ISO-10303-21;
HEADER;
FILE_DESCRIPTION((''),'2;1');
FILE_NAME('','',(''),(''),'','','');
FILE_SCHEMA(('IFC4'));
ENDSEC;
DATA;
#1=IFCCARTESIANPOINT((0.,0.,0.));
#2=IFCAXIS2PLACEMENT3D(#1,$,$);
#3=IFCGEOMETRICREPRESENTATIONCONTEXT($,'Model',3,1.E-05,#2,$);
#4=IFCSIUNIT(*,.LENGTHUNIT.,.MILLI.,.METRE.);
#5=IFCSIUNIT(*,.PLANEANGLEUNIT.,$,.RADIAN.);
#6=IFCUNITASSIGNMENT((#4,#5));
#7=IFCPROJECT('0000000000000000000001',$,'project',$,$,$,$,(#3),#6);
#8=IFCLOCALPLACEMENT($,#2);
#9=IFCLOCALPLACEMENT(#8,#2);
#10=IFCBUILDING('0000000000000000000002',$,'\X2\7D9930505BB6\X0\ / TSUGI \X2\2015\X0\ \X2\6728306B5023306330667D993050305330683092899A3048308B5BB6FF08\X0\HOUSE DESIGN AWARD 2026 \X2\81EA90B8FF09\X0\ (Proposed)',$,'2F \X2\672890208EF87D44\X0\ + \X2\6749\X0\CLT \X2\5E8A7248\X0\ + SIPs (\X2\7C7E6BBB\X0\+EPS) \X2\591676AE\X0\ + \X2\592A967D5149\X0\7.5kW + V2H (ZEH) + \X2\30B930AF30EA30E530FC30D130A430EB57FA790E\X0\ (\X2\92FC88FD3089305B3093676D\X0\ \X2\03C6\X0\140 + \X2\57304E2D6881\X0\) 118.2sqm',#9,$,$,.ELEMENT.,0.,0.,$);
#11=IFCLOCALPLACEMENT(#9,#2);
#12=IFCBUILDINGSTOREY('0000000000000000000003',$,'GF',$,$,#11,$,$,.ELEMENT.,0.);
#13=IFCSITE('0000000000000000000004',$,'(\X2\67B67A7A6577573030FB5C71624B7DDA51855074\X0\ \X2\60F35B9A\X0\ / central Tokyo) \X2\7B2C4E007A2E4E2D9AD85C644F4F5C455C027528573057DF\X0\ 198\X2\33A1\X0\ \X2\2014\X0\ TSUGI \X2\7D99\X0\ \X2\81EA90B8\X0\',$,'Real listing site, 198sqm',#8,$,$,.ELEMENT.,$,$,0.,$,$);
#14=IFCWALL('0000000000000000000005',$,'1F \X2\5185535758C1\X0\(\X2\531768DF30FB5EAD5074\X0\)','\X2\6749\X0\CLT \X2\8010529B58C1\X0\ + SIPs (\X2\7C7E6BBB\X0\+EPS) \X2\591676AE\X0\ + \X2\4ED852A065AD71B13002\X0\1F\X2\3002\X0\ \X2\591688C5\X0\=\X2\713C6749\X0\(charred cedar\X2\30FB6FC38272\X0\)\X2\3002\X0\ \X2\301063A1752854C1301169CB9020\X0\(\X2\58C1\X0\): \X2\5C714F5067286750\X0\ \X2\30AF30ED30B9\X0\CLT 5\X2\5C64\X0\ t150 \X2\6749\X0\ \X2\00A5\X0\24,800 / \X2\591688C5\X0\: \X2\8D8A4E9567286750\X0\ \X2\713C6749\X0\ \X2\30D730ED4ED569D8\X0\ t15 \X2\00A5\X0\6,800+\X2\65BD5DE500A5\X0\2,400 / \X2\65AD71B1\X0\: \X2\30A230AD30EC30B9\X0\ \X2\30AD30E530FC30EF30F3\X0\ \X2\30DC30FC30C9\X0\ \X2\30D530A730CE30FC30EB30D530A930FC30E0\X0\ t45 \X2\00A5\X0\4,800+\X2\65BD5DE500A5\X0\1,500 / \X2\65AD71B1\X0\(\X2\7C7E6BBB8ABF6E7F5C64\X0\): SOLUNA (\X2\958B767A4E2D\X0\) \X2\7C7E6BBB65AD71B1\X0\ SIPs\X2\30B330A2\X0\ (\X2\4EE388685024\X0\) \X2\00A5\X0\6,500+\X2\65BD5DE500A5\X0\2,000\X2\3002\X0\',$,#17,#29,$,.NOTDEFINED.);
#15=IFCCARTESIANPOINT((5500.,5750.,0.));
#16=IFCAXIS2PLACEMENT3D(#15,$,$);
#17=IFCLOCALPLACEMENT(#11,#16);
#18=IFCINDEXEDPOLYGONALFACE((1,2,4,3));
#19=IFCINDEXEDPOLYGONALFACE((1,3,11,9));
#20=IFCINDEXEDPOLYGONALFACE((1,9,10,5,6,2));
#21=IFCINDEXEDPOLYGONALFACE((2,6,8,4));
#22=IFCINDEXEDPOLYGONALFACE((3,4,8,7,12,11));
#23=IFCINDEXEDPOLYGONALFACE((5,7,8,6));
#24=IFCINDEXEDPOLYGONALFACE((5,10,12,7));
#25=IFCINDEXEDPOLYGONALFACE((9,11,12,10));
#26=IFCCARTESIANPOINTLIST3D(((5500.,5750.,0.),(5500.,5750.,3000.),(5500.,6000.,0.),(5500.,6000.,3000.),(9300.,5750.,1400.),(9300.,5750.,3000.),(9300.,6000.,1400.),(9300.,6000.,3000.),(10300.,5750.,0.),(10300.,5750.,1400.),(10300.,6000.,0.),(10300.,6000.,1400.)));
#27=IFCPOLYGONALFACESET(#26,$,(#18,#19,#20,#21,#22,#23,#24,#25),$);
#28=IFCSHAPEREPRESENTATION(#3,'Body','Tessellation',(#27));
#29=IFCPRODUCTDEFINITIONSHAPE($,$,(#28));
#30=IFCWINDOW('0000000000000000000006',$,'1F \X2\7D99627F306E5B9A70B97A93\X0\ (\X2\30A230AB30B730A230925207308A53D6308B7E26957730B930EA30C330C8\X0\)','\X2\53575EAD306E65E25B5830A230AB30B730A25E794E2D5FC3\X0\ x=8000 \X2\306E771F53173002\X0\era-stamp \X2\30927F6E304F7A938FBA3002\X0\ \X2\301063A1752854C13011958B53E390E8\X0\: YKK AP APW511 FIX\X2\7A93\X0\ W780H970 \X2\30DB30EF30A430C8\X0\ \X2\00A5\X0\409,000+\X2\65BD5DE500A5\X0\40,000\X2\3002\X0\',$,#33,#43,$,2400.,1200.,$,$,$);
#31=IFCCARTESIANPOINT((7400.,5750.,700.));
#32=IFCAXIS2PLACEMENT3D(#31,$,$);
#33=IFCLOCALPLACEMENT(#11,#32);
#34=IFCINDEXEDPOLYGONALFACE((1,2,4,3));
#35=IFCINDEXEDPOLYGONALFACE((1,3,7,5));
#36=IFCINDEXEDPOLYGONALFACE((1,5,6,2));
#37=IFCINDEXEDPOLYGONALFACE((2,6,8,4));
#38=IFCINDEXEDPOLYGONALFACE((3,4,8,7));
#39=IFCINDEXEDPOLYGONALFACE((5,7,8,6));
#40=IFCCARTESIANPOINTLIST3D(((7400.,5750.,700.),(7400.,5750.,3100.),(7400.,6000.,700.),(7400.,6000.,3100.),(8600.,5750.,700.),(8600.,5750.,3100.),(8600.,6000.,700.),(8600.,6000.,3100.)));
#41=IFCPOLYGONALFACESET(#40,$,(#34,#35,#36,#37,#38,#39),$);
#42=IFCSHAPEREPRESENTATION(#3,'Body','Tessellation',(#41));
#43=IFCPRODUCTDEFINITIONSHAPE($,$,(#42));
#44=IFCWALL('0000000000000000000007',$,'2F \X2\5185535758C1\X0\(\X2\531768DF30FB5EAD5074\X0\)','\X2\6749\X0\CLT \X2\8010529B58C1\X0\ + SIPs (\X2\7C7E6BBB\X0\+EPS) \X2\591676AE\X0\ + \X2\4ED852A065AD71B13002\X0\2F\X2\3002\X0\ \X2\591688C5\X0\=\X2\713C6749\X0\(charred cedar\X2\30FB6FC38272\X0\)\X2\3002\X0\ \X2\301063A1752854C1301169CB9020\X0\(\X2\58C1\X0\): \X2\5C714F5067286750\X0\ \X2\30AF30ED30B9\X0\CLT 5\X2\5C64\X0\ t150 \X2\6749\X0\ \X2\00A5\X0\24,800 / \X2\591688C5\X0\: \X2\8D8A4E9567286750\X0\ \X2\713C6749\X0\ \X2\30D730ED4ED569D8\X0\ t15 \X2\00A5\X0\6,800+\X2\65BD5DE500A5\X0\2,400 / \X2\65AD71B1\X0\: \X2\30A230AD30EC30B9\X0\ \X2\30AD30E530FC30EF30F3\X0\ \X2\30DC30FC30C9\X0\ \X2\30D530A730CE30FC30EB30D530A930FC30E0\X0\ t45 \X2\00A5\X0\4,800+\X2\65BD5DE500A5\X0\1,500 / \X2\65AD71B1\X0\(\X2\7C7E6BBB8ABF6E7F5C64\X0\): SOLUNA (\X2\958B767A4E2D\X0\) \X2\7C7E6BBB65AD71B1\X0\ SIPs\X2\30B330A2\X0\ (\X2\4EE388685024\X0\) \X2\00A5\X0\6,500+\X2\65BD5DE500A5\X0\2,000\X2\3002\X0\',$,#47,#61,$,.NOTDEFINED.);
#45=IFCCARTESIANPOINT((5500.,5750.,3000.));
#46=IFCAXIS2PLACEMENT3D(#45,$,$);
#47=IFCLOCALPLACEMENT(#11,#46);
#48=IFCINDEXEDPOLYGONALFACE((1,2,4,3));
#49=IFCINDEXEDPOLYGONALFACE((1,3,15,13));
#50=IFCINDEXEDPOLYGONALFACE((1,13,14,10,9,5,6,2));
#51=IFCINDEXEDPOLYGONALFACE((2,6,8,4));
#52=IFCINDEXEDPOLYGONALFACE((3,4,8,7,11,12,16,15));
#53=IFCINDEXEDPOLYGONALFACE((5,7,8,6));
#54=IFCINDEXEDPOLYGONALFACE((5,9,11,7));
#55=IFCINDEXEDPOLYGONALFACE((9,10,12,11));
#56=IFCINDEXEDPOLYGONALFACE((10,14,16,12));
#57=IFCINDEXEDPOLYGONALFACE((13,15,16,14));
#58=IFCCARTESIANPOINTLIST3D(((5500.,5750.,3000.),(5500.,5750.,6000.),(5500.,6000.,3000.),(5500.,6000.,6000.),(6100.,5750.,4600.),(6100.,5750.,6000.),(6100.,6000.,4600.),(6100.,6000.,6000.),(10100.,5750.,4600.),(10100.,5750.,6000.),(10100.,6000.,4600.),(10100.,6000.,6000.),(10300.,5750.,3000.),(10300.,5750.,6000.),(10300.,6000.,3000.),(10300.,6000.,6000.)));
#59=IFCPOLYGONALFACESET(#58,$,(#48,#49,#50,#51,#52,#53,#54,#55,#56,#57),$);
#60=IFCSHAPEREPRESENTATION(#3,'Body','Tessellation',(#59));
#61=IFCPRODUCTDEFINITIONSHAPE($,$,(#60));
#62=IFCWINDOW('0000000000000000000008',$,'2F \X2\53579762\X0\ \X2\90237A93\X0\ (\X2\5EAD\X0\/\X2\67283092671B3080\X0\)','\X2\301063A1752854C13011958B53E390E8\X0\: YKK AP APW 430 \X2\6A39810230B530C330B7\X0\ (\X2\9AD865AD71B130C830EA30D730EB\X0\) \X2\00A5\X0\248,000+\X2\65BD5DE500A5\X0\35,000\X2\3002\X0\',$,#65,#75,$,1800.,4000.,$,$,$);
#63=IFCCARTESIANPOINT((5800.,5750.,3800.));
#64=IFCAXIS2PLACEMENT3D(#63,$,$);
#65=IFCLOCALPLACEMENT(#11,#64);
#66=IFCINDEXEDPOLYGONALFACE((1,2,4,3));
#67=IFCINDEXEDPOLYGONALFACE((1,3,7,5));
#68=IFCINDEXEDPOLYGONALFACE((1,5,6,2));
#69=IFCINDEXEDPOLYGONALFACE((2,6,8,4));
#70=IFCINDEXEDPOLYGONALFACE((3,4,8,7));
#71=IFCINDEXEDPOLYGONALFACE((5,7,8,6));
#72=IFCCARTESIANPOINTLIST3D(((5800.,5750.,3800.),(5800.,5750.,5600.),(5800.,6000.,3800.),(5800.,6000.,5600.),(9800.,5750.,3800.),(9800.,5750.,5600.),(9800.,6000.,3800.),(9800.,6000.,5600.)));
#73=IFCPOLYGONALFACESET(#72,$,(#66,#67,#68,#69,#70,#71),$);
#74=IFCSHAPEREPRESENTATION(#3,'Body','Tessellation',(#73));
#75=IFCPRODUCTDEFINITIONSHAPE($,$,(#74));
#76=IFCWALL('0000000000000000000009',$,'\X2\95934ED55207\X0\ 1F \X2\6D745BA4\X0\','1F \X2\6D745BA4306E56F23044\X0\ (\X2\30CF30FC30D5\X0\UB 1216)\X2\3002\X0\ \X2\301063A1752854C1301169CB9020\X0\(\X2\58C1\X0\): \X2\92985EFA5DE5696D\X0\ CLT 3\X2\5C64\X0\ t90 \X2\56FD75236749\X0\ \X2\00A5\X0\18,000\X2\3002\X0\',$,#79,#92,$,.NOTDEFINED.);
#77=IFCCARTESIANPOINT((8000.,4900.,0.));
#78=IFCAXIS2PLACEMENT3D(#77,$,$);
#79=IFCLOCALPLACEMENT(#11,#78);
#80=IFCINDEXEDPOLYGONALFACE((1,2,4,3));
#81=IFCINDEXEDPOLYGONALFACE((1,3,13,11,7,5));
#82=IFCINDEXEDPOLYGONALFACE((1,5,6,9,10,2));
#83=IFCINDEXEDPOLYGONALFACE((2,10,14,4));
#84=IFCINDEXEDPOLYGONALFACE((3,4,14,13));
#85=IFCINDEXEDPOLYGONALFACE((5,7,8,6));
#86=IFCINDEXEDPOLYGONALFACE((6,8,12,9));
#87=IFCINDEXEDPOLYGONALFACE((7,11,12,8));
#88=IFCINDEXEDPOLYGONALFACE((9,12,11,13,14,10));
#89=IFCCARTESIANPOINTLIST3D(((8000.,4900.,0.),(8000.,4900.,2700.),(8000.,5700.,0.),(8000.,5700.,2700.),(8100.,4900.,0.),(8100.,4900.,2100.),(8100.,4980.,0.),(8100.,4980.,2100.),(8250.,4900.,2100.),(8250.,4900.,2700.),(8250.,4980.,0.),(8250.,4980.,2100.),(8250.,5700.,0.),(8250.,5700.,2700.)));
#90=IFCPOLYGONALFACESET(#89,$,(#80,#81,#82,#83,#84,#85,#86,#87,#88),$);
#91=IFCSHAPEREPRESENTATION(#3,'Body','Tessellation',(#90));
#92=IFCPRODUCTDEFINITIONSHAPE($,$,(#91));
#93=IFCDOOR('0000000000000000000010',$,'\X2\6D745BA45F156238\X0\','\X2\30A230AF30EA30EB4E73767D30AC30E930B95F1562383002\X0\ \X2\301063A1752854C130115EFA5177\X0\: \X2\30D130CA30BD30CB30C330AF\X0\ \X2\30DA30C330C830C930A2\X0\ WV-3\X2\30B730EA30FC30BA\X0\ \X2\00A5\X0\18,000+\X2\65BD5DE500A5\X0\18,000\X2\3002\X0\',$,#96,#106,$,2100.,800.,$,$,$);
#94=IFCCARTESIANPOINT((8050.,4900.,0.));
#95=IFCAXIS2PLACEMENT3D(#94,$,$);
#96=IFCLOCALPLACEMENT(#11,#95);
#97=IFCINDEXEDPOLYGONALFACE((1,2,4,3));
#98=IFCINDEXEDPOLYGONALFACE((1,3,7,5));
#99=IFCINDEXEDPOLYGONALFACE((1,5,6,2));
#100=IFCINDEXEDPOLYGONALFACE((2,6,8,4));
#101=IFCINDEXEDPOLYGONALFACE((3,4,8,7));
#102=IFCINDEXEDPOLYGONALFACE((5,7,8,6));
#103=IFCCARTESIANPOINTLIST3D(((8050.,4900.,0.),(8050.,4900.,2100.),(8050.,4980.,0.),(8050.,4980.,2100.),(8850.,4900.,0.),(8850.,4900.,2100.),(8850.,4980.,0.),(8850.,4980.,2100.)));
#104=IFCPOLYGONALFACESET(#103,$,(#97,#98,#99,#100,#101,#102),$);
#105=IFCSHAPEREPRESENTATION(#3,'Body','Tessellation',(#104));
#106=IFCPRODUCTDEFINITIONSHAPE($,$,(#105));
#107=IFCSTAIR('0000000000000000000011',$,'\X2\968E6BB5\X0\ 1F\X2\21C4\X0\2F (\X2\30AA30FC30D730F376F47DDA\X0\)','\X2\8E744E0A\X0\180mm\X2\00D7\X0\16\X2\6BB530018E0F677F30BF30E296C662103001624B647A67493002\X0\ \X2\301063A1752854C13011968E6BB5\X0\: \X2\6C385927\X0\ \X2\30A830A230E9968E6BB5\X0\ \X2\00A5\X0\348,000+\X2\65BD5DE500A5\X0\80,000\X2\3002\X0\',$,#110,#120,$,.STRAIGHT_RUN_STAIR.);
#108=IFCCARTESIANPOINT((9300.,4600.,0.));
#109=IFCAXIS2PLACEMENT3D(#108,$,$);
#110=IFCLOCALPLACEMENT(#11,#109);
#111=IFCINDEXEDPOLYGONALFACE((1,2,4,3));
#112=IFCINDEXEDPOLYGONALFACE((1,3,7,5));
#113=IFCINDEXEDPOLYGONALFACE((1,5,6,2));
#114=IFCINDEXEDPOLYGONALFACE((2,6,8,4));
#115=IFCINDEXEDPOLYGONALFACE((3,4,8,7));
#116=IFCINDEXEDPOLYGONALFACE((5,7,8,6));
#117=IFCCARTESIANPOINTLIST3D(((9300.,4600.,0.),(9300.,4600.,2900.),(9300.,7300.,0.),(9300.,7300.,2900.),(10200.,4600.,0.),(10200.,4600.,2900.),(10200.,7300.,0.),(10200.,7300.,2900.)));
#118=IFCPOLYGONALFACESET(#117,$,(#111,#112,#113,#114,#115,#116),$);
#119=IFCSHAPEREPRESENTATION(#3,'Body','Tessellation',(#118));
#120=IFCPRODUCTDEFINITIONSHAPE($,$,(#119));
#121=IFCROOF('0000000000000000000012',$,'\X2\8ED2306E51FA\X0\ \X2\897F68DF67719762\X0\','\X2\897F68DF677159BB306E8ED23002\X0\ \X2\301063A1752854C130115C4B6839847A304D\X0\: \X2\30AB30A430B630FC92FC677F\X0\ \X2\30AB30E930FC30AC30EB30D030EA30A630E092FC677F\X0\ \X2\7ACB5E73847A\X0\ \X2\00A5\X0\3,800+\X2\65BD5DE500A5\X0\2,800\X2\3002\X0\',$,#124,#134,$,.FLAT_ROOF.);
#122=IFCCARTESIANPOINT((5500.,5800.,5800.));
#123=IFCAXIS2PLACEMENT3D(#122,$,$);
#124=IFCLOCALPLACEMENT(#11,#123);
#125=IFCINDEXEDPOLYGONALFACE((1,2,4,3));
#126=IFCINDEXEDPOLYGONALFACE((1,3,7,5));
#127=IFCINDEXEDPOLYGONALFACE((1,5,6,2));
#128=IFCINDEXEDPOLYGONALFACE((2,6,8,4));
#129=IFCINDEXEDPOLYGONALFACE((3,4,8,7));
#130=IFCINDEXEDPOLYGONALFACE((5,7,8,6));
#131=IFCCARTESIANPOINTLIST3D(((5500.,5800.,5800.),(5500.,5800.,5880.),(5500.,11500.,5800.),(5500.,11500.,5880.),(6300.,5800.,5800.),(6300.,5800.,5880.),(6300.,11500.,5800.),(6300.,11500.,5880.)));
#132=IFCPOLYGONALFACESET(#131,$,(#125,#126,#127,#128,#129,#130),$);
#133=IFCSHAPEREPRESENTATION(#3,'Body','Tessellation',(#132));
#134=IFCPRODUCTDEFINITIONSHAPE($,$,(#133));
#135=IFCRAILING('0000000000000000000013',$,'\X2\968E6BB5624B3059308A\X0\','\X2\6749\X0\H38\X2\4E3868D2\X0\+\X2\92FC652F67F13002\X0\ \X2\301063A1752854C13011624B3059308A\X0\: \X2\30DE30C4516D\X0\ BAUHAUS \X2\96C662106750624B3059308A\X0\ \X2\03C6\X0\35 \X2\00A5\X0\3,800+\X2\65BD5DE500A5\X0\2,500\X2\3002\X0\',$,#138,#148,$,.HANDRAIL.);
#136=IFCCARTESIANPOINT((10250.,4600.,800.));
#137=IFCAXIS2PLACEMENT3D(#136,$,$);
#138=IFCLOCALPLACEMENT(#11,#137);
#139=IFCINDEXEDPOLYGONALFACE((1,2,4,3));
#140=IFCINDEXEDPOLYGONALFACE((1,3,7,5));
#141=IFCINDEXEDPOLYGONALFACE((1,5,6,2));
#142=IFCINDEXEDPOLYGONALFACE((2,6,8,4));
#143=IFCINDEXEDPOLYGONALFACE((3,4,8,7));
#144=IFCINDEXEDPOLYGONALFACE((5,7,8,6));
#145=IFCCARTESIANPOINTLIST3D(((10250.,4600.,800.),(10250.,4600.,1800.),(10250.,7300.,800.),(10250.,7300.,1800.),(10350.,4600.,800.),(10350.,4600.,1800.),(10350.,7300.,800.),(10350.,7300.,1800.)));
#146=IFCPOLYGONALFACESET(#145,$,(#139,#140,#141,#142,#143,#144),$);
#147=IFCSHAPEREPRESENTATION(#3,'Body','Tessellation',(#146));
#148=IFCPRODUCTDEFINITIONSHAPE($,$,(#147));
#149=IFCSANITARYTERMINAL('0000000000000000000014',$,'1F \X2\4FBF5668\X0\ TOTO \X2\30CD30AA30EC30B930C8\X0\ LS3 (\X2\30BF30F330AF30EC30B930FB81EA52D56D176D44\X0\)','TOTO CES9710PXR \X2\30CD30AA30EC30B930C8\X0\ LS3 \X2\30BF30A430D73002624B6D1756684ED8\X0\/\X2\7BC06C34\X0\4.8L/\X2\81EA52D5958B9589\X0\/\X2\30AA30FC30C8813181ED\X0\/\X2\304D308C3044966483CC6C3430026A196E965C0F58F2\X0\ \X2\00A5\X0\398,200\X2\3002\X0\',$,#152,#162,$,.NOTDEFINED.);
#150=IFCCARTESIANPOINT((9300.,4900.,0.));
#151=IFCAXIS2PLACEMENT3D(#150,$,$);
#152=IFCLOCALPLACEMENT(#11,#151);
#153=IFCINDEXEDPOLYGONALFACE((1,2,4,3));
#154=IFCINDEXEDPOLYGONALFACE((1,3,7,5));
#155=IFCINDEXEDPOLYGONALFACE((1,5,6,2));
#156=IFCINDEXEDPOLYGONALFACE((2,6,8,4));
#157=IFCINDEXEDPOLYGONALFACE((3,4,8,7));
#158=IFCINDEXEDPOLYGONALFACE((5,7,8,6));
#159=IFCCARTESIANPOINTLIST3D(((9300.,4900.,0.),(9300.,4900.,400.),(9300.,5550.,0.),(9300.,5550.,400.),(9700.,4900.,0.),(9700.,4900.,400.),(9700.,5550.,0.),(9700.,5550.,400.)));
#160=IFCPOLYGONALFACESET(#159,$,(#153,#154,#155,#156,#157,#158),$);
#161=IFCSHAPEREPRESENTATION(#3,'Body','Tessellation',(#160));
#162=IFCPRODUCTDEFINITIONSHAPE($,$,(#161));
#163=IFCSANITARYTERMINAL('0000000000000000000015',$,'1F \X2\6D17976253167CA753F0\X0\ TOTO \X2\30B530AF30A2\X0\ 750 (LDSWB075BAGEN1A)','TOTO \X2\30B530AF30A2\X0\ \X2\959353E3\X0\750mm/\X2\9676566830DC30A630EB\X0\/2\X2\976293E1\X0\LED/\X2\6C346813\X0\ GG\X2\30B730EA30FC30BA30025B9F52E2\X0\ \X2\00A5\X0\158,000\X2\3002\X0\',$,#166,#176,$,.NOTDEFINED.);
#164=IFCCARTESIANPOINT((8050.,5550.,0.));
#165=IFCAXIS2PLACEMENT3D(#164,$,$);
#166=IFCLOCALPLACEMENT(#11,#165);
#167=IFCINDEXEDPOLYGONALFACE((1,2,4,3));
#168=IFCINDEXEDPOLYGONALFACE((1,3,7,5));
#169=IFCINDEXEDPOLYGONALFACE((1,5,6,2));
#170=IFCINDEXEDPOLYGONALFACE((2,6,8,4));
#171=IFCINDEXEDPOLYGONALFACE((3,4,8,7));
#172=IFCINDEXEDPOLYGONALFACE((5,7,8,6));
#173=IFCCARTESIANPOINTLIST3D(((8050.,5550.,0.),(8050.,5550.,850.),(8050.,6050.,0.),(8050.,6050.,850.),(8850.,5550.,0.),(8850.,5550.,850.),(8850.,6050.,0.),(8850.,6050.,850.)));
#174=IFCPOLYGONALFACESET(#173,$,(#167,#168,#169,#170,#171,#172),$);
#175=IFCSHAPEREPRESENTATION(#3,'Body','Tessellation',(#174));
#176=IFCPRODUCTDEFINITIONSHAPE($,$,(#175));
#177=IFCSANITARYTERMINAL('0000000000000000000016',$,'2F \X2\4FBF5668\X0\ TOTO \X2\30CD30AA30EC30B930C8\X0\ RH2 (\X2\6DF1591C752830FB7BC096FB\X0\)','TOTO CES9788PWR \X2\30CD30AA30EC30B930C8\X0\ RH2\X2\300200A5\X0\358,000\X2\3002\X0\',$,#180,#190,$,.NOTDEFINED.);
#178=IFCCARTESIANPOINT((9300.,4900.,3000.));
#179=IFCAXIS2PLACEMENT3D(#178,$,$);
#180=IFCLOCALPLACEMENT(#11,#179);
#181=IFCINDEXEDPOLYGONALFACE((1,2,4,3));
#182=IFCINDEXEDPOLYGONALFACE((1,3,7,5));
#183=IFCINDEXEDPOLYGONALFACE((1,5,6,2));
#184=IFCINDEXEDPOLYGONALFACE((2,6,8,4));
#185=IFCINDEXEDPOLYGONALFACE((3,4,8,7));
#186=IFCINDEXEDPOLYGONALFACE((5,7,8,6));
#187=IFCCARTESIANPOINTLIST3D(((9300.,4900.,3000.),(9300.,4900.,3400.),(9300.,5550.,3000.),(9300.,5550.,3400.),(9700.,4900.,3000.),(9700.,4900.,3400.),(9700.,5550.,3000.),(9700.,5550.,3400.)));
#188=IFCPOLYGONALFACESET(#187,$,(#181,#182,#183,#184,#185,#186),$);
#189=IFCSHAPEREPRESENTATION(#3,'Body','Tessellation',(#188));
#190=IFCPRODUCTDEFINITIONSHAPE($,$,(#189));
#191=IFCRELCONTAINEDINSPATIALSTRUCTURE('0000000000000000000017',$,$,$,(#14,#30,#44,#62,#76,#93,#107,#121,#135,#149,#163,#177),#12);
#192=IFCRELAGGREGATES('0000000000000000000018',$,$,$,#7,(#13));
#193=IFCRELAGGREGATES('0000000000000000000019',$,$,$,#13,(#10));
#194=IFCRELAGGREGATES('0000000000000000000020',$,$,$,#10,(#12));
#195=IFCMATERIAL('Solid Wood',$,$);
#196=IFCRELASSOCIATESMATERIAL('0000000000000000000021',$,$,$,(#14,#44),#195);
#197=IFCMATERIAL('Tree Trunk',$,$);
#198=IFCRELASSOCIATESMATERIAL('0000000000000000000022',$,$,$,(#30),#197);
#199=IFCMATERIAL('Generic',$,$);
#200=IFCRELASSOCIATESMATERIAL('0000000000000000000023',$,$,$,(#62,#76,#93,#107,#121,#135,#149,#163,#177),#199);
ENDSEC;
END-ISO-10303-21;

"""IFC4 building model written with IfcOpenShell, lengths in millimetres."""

from ifc_helpers import new_model, si_unit, frame, frame_2d, origin, place, context, project, spatial, rectangle, extrude, material, element, fill, save


model = new_model("IFC4")

# Units and contexts
model_context = context("Model", 3, precision=1e-05, world=origin())
ifc_project = project(units=[si_unit("LENGTHUNIT", "METRE", prefix="MILLI"), si_unit("PLANEANGLEUNIT", "RADIAN")], contexts=[model_context])

# Site, building, storey
site_placement = place(None, origin())
site = spatial("IfcSite", under=ifc_project, at=site_placement, Name="(架空敷地・山手線内側 想定 / central Tokyo) 第一種中高層住居専用地域 198㎡ — TSUGI 継 自邸", ObjectType="Real listing site, 198sqm", CompositionType="ELEMENT", RefElevation=0.0)
building_placement = place(site_placement, origin())
building = spatial("IfcBuilding", under=site, at=building_placement, Name="継ぐ家 / TSUGI ― 木に倣って継ぐことを覚える家（HOUSE DESIGN AWARD 2026 自邸） (Proposed)", ObjectType="2F 木造軸組 + 杉CLT 床版 + SIPs (籾殻+EPS) 外皮 + 太陽光7.5kW + V2H (ZEH) + スクリューパイル基礎 (鋼製らせん杭 φ140 + 地中梁) 118.2sqm", CompositionType="ELEMENT", ElevationOfRefHeight=0.0, ElevationOfTerrain=0.0)
storey_placement = place(building_placement, origin())
storey = spatial("IfcBuildingStorey", under=building, at=storey_placement, Name="GF", CompositionType="ELEMENT", Elevation=0.0)

# Walls, openings, windows
ifc_material_1 = material(Name="Solid Wood")
wall_1_placement = place(storey_placement, frame((5500.0, 5750.0, 0.0)))
wall_1 = element("IfcWall", 1, at=wall_1_placement, inside=storey, material=ifc_material_1, Name="1F 内南壁(北棟・庭側)", Description="杉CLT 耐力壁 + SIPs (籾殻+EPS) 外皮 + 付加断熱。1F。 外装=焼杉(charred cedar・濃色)。 【採用品】構造(壁): 山佐木材 クロスCLT 5層 t150 杉 ¥24,800 / 外装: 越井木材 焼杉 プロ仕様 t15 ¥6,800+施工¥2,400 / 断熱: アキレス キューワン ボード フェノールフォーム t45 ¥4,800+施工¥1,500 / 断熱(籾殻調湿層): SOLUNA (開発中) 籾殻断熱 SIPsコア (代表値) ¥6,500+施工¥2,000。", PredefinedType="NOTDEFINED", context=model_context, shape_type="SweptSolid", body=[
    extrude(rectangle(XDim=4800.0, YDim=250.0, at=frame_2d((2400.0, 125.0))), frame((5500.0, 5750.0, 0.0)), (0.0, 0.0, 1.0), 3000.0),
])
opening_1_placement = place(storey_placement, frame((7400.0, 5750.0, 700.0)))
opening_1 = element("IfcOpeningElement", 2, at=opening_1_placement, cuts=wall_1, PredefinedType="NOTDEFINED", context=model_context, shape_type="SweptSolid", body=[
    extrude(rectangle(XDim=1200.0, YDim=250.0, at=frame_2d((600.0, 125.0))), frame((7400.0, 5750.0, 700.0)), (0.0, 0.0, 1.0), 2400.0),
])
ifc_material_2 = material(Name="Tree Trunk")
window_1_placement = place(storey_placement, frame((7400.0, 5750.0, 700.0)))
window_1 = element("IfcWindow", 3, at=window_1_placement, inside=storey, material=ifc_material_2, Name="1F 継承の定点窓 (アカシアを切り取る縦長スリット)", Description="南庭の既存アカシア幹中心 x=8000 の真北。era-stamp を置く窓辺。 【採用品】開口部: YKK AP APW511 FIX窓 W780H970 ホワイト ¥409,000+施工¥40,000。", OverallHeight=2400.0, OverallWidth=1200.0, context=model_context, shape_type="SweptSolid", body=[
    extrude(rectangle(XDim=1200.0, YDim=250.0, at=frame_2d((600.0, 125.0))), frame((7400.0, 5750.0, 700.0)), (0.0, 0.0, 1.0), 2400.0),
])
fill(opening_1, window_1)
wall_2_placement = place(storey_placement, frame((5500.0, 5750.0, 3000.0)))
wall_2 = element("IfcWall", 4, at=wall_2_placement, inside=storey, material=ifc_material_1, Name="2F 内南壁(北棟・庭側)", Description="杉CLT 耐力壁 + SIPs (籾殻+EPS) 外皮 + 付加断熱。2F。 外装=焼杉(charred cedar・濃色)。 【採用品】構造(壁): 山佐木材 クロスCLT 5層 t150 杉 ¥24,800 / 外装: 越井木材 焼杉 プロ仕様 t15 ¥6,800+施工¥2,400 / 断熱: アキレス キューワン ボード フェノールフォーム t45 ¥4,800+施工¥1,500 / 断熱(籾殻調湿層): SOLUNA (開発中) 籾殻断熱 SIPsコア (代表値) ¥6,500+施工¥2,000。", PredefinedType="NOTDEFINED", context=model_context, shape_type="SweptSolid", body=[
    extrude(rectangle(XDim=4800.0, YDim=250.0, at=frame_2d((2400.0, 125.0))), frame((5500.0, 5750.0, 3000.0)), (0.0, 0.0, 1.0), 3000.0),
])
opening_2_placement = place(storey_placement, frame((5800.0, 5750.0, 3800.0)))
opening_2 = element("IfcOpeningElement", 5, at=opening_2_placement, cuts=wall_2, PredefinedType="NOTDEFINED", context=model_context, shape_type="SweptSolid", body=[
    extrude(rectangle(XDim=4000.0, YDim=250.0, at=frame_2d((2000.0, 125.0))), frame((5800.0, 5750.0, 3800.0)), (0.0, 0.0, 1.0), 1800.0),
])
ifc_material_3 = material(Name="Generic")
window_2_placement = place(storey_placement, frame((5800.0, 5750.0, 3800.0)))
window_2 = element("IfcWindow", 6, at=window_2_placement, inside=storey, material=ifc_material_3, Name="2F 南面 連窓 (庭/木を望む)", Description="【採用品】開口部: YKK AP APW 430 樹脂サッシ (高断熱トリプル) ¥248,000+施工¥35,000。", OverallHeight=1800.0, OverallWidth=4000.0, context=model_context, shape_type="SweptSolid", body=[
    extrude(rectangle(XDim=4000.0, YDim=250.0, at=frame_2d((2000.0, 125.0))), frame((5800.0, 5750.0, 3800.0)), (0.0, 0.0, 1.0), 1800.0),
])
fill(opening_2, window_2)

# Wall, opening, door
wall_3_placement = place(storey_placement, frame((8000.0, 4900.0, 0.0)))
wall_3 = element("IfcWall", 7, at=wall_3_placement, inside=storey, material=ifc_material_3, Name="間仕切 1F 浴室", Description="1F 浴室の囲い (ハーフUB 1216)。 【採用品】構造(壁): 銘建工業 CLT 3層 t90 国産杉 ¥18,000。", PredefinedType="NOTDEFINED", context=model_context, shape_type="SweptSolid", body=[
    extrude(rectangle(XDim=250.0, YDim=800.0, at=frame_2d((125.0, 400.0))), frame((8000.0, 4900.0, 0.0)), (0.0, 0.0, 1.0), 2700.0),
])
opening_3_placement = place(storey_placement, frame((8050.0, 4900.0, 0.0)))
opening_3 = element("IfcOpeningElement", 8, at=opening_3_placement, cuts=wall_3, PredefinedType="NOTDEFINED", context=model_context, shape_type="SweptSolid", body=[
    extrude(rectangle(XDim=800.0, YDim=80.0, at=frame_2d((400.0, 40.0))), frame((8050.0, 4900.0, 0.0)), (0.0, 0.0, 1.0), 2100.0),
])
door_placement = place(storey_placement, frame((8050.0, 4900.0, 0.0)))
door = element("IfcDoor", 9, at=door_placement, inside=storey, material=ifc_material_3, Name="浴室引戸", Description="アクリル乳白ガラス引戸。 【採用品】建具: パナソニック ペットドア WV-3シリーズ ¥18,000+施工¥18,000。", OverallHeight=2100.0, OverallWidth=800.0, context=model_context, shape_type="SweptSolid", body=[
    extrude(rectangle(XDim=800.0, YDim=80.0, at=frame_2d((400.0, 40.0))), frame((8050.0, 4900.0, 0.0)), (0.0, 0.0, 1.0), 2100.0),
])
fill(opening_3, door)

# Stair
stair_placement = place(storey_placement, frame((9300.0, 4600.0, 0.0)))
element("IfcStair", 10, at=stair_placement, inside=storey, material=ifc_material_3, Name="階段 1F⇄2F (オープン直線)", Description="蹴上180mm×16段、踏板タモ集成、手摺杉。 【採用品】階段: 永大 エアラ階段 ¥348,000+施工¥80,000。", PredefinedType="STRAIGHT_RUN_STAIR", context=model_context, shape_type="SweptSolid", body=[
    extrude(rectangle(XDim=900.0, YDim=2700.0, at=frame_2d((450.0, 1350.0))), frame((9300.0, 4600.0, 0.0)), (0.0, 0.0, 1.0), 2900.0),
])

# Roof
roof_placement = place(storey_placement, frame((5500.0, 5800.0, 5800.0)))
element("IfcRoof", 11, at=roof_placement, inside=storey, material=ifc_material_3, Name="軒の出 西棟東面", Description="西棟東妻の軒。 【採用品】屋根葺き: カイザー鋼板 カラーガルバリウム鋼板 立平葺 ¥3,800+施工¥2,800。", PredefinedType="FLAT_ROOF", context=model_context, shape_type="SweptSolid", body=[
    extrude(rectangle(XDim=800.0, YDim=5700.0, at=frame_2d((400.0, 2850.0))), frame((5500.0, 5800.0, 5800.0)), (0.0, 0.0, 1.0), 80.0),
])

# Railing
railing_placement = place(storey_placement, frame((10250.0, 4600.0, 800.0)))
element("IfcRailing", 12, at=railing_placement, inside=storey, material=ifc_material_3, Name="階段手すり", Description="杉H38丸棒+鋼支柱。 【採用品】手すり: マツ六 BAUHAUS 集成材手すり φ35 ¥3,800+施工¥2,500。", PredefinedType="HANDRAIL", context=model_context, shape_type="SweptSolid", body=[
    extrude(rectangle(XDim=100.0, YDim=2700.0, at=frame_2d((50.0, 1350.0))), frame((10250.0, 4600.0, 800.0)), (0.0, 0.0, 1.0), 1000.0),
])

# Sanitary terminals
sanitary_terminal_1_placement = place(storey_placement, frame((9300.0, 4900.0, 0.0)))
element("IfcSanitaryTerminal", 13, at=sanitary_terminal_1_placement, inside=storey, material=ifc_material_3, Name="1F 便器 TOTO ネオレスト LS3 (タンクレス・自動洗浄)", Description="TOTO CES9710PXR ネオレスト LS3 タイプ。手洗器付/節水4.8L/自動開閉/オート脱臭/きれい除菌水。標準小売 ¥398,200。", PredefinedType="NOTDEFINED", context=model_context, shape_type="SweptSolid", body=[
    extrude(rectangle(XDim=400.0, YDim=650.0, at=frame_2d((200.0, 325.0))), frame((9300.0, 4900.0, 0.0)), (0.0, 0.0, 1.0), 400.0),
])
sanitary_terminal_2_placement = place(storey_placement, frame((8050.0, 5550.0, 0.0)))
element("IfcSanitaryTerminal", 14, at=sanitary_terminal_2_placement, inside=storey, material=ifc_material_3, Name="1F 洗面化粧台 TOTO サクア 750 (LDSWB075BAGEN1A)", Description="TOTO サクア 間口750mm/陶器ボウル/2面鏡LED/水栓 GGシリーズ。実勢 ¥158,000。", PredefinedType="NOTDEFINED", context=model_context, shape_type="SweptSolid", body=[
    extrude(rectangle(XDim=800.0, YDim=500.0, at=frame_2d((400.0, 250.0))), frame((8050.0, 5550.0, 0.0)), (0.0, 0.0, 1.0), 850.0),
])
sanitary_terminal_3_placement = place(storey_placement, frame((9300.0, 4900.0, 3000.0)))
element("IfcSanitaryTerminal", 15, at=sanitary_terminal_3_placement, inside=storey, material=ifc_material_3, Name="2F 便器 TOTO ネオレスト RH2 (深夜用・節電)", Description="TOTO CES9788PWR ネオレスト RH2。¥358,000。", PredefinedType="NOTDEFINED", context=model_context, shape_type="SweptSolid", body=[
    extrude(rectangle(XDim=400.0, YDim=650.0, at=frame_2d((200.0, 325.0))), frame((9300.0, 4900.0, 3000.0)), (0.0, 0.0, 1.0), 400.0),
])

save(model, "model.ifc")
